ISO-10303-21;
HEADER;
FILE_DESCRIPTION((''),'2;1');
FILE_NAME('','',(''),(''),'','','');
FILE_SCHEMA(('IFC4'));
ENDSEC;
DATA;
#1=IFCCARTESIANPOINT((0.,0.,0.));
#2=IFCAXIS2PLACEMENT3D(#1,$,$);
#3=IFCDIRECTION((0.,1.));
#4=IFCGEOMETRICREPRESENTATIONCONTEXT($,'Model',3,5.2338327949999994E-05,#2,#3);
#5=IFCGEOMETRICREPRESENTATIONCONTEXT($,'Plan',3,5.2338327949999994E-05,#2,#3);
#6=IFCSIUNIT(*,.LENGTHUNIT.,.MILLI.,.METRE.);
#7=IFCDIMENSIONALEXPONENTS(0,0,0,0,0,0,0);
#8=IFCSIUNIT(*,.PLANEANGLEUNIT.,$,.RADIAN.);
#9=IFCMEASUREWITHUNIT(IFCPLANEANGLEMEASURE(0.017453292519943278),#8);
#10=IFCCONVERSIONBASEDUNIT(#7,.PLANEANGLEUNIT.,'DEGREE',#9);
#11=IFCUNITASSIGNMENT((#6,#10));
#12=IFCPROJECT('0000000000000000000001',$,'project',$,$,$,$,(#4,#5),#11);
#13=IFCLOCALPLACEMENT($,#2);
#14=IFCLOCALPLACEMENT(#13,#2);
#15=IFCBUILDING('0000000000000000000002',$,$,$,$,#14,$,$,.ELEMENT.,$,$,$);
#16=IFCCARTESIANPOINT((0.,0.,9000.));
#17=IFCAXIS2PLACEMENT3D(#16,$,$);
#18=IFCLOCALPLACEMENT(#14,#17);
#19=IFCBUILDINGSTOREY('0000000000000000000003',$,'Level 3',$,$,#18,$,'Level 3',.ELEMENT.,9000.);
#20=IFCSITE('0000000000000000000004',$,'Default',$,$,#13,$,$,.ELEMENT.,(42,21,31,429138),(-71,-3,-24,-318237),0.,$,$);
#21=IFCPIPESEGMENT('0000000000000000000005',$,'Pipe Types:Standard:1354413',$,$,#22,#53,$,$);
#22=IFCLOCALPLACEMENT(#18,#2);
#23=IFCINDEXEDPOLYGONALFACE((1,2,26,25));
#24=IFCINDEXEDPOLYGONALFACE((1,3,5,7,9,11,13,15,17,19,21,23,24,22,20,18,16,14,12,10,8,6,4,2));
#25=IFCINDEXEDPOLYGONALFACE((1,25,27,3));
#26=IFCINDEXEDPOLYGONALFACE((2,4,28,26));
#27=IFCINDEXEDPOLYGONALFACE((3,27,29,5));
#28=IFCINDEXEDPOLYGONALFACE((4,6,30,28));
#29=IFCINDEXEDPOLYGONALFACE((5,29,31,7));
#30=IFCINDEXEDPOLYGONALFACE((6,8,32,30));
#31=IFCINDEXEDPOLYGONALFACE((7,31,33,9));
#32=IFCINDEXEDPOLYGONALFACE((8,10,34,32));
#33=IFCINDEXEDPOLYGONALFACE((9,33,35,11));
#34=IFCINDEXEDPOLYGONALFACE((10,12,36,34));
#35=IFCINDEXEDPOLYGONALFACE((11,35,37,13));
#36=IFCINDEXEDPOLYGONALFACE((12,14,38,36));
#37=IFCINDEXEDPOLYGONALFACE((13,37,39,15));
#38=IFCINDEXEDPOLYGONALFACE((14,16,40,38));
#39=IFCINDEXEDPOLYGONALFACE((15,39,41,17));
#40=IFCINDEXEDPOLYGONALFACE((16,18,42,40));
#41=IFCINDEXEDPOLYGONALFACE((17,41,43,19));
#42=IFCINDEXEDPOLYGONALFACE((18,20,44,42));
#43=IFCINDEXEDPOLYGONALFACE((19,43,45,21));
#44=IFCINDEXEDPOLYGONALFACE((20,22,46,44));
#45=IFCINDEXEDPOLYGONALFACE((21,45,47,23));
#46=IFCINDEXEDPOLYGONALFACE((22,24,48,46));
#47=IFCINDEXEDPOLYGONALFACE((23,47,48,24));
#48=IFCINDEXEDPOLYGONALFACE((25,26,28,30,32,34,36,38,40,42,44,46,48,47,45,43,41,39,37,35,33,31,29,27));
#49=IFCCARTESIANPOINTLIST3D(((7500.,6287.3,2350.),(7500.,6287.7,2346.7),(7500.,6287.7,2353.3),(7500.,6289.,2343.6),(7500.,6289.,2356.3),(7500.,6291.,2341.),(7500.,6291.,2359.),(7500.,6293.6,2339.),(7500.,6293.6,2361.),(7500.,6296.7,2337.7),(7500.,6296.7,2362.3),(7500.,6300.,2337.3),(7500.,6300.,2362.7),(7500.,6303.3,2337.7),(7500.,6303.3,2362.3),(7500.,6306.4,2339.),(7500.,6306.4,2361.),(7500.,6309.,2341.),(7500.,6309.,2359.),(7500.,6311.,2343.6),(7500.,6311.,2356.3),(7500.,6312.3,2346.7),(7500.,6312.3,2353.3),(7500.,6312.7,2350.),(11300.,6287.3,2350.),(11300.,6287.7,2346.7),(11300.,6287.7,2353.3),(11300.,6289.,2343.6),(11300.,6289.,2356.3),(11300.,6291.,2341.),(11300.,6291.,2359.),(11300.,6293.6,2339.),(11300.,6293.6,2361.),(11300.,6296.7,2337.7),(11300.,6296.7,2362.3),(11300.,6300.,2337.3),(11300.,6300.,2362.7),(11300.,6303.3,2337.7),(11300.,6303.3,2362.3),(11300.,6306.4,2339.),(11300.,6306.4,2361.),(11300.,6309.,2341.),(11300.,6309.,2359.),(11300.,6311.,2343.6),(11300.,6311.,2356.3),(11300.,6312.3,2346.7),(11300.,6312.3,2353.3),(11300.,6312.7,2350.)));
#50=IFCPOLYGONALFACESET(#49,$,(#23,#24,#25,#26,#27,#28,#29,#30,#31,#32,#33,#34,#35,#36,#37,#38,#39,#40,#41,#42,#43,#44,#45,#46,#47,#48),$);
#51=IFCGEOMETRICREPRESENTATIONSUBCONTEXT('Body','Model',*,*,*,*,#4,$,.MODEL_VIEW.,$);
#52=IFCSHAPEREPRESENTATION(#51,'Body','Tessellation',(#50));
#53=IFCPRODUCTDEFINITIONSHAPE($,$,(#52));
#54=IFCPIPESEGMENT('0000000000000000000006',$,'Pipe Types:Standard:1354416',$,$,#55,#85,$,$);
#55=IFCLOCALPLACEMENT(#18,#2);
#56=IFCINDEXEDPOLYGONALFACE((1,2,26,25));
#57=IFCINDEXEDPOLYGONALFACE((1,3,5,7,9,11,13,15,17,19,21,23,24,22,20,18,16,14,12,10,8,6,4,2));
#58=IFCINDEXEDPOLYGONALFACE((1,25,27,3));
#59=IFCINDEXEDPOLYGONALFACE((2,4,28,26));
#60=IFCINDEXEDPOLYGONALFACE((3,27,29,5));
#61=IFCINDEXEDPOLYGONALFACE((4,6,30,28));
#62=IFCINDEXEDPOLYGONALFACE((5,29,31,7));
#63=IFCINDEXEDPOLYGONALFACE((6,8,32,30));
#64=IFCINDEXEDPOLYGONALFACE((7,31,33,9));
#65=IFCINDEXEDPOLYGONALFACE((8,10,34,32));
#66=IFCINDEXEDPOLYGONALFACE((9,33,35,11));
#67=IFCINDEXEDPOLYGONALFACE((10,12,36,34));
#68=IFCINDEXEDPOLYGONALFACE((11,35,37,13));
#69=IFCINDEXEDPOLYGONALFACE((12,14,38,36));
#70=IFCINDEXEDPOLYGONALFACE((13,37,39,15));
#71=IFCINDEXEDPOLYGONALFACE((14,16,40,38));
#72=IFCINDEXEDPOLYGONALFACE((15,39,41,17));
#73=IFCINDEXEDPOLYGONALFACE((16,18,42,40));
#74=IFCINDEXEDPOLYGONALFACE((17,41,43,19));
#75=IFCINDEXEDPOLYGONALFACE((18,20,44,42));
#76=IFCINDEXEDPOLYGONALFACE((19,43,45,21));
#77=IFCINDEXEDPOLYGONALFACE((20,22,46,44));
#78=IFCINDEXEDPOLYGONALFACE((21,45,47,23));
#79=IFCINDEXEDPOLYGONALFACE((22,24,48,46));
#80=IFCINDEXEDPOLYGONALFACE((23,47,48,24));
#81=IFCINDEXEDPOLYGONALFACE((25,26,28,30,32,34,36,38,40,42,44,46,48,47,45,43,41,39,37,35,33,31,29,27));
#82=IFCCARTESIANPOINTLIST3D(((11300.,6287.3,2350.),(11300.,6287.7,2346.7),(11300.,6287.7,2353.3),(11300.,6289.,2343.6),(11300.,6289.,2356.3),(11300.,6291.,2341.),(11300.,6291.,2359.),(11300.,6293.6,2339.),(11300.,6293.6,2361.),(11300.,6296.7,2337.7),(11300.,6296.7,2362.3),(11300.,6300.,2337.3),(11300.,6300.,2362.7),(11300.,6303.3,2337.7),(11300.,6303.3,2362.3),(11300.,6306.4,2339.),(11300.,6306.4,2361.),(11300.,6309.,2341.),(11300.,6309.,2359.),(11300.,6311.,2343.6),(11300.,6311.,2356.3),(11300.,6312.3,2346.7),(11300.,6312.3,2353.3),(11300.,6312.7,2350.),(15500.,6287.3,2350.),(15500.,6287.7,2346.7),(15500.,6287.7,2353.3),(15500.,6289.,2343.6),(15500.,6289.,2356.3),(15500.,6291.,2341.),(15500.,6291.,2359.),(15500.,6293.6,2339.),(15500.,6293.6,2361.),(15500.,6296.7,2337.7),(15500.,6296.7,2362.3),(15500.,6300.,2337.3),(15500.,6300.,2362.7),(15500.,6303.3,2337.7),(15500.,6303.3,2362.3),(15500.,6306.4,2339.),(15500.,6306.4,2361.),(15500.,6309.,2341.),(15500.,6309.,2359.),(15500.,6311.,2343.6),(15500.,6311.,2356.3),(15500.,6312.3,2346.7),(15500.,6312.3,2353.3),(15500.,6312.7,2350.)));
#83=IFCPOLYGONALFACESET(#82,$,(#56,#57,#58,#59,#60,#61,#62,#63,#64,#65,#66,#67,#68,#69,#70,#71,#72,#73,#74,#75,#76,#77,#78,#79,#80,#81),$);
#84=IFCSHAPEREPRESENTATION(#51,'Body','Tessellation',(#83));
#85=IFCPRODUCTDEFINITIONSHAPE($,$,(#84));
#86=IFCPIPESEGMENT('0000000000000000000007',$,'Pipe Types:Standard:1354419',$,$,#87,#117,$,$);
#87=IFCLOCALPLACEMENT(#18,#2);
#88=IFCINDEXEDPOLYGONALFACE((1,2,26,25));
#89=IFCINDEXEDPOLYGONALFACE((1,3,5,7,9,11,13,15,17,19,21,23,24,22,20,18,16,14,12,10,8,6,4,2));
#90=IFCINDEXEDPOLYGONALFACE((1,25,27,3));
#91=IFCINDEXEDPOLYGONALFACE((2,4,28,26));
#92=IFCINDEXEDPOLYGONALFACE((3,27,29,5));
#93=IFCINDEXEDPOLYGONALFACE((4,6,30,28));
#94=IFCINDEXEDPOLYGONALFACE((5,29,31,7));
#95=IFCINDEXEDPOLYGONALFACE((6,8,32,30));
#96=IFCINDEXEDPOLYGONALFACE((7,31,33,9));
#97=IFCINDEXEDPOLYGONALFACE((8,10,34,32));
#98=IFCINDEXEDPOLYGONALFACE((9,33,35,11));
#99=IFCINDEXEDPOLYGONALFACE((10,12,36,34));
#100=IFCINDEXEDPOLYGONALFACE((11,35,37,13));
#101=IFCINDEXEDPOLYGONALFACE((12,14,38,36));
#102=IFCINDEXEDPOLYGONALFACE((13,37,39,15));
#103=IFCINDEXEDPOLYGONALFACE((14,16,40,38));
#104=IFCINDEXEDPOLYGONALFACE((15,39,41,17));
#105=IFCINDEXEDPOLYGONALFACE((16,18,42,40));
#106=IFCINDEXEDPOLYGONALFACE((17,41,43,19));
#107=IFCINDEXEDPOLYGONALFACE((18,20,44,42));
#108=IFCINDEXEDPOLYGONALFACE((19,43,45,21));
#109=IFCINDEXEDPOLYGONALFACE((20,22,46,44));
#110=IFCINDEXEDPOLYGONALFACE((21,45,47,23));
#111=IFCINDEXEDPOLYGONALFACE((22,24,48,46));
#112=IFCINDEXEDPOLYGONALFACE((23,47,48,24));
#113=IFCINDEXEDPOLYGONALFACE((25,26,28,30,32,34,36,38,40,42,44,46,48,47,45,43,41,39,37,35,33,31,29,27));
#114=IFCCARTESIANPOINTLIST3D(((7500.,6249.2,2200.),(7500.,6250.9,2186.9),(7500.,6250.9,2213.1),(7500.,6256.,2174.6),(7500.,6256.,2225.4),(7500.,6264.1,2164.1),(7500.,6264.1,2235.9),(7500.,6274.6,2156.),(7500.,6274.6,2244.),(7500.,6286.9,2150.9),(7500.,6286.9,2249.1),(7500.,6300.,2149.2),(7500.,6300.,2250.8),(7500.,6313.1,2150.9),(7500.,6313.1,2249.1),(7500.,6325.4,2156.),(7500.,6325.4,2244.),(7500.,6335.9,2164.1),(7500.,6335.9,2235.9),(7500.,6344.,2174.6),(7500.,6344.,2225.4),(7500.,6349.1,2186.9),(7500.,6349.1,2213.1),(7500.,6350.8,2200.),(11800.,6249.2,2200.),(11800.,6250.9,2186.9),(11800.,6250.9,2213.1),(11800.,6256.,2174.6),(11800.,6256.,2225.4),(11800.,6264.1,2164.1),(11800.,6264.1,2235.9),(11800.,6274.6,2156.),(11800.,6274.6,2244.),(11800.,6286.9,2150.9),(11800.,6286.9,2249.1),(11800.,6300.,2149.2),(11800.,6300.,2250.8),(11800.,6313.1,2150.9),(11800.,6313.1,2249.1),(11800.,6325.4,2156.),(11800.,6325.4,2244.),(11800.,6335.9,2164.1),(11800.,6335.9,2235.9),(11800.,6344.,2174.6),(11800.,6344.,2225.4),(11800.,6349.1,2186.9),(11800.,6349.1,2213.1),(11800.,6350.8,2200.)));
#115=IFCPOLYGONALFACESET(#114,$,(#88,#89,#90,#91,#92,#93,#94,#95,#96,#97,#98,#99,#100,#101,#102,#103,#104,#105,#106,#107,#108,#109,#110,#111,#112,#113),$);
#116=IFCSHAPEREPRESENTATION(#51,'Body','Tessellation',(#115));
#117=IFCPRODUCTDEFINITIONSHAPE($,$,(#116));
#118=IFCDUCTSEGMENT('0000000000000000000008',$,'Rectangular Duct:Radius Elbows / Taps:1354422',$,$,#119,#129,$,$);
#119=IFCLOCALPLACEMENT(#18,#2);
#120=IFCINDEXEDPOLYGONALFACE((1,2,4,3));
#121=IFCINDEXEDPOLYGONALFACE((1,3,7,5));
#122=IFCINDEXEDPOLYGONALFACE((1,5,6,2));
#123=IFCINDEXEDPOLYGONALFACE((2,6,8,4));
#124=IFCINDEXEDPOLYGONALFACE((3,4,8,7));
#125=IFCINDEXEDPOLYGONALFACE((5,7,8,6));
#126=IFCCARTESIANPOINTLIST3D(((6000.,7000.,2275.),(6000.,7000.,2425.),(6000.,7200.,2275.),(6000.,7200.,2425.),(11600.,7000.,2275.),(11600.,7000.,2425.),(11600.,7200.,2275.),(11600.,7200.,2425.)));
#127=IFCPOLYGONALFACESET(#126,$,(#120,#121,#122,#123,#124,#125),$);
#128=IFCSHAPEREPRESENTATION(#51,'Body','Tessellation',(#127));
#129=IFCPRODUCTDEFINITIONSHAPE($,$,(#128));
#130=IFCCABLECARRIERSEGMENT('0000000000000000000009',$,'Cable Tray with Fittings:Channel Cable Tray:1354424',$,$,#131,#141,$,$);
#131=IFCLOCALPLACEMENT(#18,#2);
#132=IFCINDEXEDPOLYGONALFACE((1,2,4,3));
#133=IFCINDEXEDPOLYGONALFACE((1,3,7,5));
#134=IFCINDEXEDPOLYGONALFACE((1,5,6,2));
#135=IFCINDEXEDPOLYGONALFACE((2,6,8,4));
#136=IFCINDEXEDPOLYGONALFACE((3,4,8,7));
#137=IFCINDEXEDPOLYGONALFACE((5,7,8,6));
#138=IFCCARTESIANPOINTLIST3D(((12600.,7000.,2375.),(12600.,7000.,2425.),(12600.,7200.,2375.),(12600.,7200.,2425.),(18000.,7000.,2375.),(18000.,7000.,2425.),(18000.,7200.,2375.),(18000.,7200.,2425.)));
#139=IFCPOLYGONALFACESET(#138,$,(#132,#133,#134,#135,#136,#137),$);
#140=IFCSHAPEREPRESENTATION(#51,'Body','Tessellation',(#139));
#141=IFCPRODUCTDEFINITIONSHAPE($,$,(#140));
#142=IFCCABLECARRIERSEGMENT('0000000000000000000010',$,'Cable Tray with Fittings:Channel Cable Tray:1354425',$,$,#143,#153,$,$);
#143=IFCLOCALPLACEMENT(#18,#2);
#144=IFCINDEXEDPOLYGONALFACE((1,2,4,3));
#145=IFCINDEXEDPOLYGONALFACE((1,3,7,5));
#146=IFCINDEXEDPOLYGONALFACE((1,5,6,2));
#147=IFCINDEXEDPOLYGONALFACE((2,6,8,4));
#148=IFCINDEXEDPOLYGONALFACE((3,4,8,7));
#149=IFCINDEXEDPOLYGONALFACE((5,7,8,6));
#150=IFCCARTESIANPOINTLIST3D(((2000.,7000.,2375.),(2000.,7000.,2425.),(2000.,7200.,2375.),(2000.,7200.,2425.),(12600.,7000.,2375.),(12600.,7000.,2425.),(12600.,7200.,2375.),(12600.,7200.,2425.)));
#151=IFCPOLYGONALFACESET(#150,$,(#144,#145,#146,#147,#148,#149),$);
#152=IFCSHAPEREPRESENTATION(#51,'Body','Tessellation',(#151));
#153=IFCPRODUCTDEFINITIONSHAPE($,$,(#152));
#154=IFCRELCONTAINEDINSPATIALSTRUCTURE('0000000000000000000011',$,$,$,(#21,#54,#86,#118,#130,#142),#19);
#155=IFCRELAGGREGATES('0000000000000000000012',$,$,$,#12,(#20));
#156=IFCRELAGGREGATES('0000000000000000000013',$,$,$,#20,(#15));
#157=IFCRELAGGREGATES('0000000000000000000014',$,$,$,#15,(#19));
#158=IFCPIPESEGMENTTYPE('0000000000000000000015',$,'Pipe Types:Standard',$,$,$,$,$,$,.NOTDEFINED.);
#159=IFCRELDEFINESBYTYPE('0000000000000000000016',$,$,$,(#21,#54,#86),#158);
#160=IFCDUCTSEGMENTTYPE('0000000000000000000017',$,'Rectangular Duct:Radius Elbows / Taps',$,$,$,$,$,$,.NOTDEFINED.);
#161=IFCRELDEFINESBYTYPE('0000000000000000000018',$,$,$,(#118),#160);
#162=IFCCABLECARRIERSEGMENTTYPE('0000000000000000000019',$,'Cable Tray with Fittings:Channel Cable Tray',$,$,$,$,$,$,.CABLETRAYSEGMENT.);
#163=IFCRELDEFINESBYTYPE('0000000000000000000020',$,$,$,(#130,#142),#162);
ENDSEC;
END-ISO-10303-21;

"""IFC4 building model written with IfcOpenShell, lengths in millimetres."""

from ifc_helpers import new_model, entity, si_unit, converted_unit, direction, frame, origin, place, context, subcontext, project, spatial, arc, indexed_curve, outline, extrude, type_object, element, save


model = new_model("IFC4")

# Units and contexts
model_context = context("Model", 3, precision=5.2338327949999994e-05, world=origin(), true_north=direction((0.0, 1.0)))
plan_context = context("Plan", 3, precision=5.2338327949999994e-05, world=origin(), true_north=direction((0.0, 1.0)))
body_context = subcontext(model_context, "Body", "Model", "MODEL_VIEW")
ifc_project = project(units=[si_unit("LENGTHUNIT", "METRE", prefix="MILLI"), converted_unit("PLANEANGLEUNIT", "DEGREE", entity("IfcPlaneAngleMeasure", 0.017453292519943278), si_unit("PLANEANGLEUNIT", "RADIAN"), dimensions=[0, 0, 0, 0, 0, 0, 0])], contexts=[model_context, plan_context])

# Site, building, storey
site_placement = place(None, origin())
site = spatial("IfcSite", under=ifc_project, at=site_placement, Name="Default", CompositionType="ELEMENT", RefLatitude=(42, 21, 31, 429138), RefLongitude=(-71, -3, -24, -318237), RefElevation=0.0)
building_placement = place(site_placement, origin())
building = spatial("IfcBuilding", under=site, at=building_placement, CompositionType="ELEMENT")
storey_placement = place(building_placement, frame((0.0, 0.0, 9000.0)))
storey = spatial("IfcBuildingStorey", under=building, at=storey_placement, Name="Level 3", LongName="Level 3", CompositionType="ELEMENT", Elevation=9000.0)

# Pipe segments
pipe_segment_type = type_object("IfcPipeSegmentType", Name="Pipe Types:Standard", PredefinedType="NOTDEFINED")
pipe_segment_1_placement = place(storey_placement, origin())
element("IfcPipeSegment", 1, at=pipe_segment_1_placement, inside=storey, type_object=pipe_segment_type, Name="Pipe Types:Standard:1354413", context=body_context, shape_type="SweptSolid", body=[
    extrude(outline(indexed_curve([(12.7, 0.0), (9.0, 9.0), (0.0, 12.7), (-9.0, 9.0), (-12.7, 0.0), (-9.0, -9.0), (0.0, -12.7), (9.0, -9.0)], segments=[arc(1, 2, 3), arc(3, 4, 5), arc(5, 6, 7), arc(7, 8, 1)], self_intersect=False)), frame((7500.0, 6300.0, 2350.0), z_axis=(1.0, 0.0, 0.0), x_axis=(0.0, 1.0, 0.0)), (0.0, 0.0, 1.0), 3800.0),
])
pipe_segment_2_placement = place(storey_placement, origin())
element("IfcPipeSegment", 2, at=pipe_segment_2_placement, inside=storey, type_object=pipe_segment_type, Name="Pipe Types:Standard:1354416", context=body_context, shape_type="SweptSolid", body=[
    extrude(outline(indexed_curve([(12.7, 0.0), (9.0, 9.0), (0.0, 12.7), (-9.0, 9.0), (-12.7, 0.0), (-9.0, -9.0), (0.0, -12.7), (9.0, -9.0)], segments=[arc(1, 2, 3), arc(3, 4, 5), arc(5, 6, 7), arc(7, 8, 1)], self_intersect=False)), frame((11300.0, 6300.0, 2350.0), z_axis=(1.0, 0.0, 0.0), x_axis=(0.0, -1.0, 0.0)), (0.0, 0.0, 1.0), 4200.0),
])
pipe_segment_3_placement = place(storey_placement, origin())
element("IfcPipeSegment", 3, at=pipe_segment_3_placement, inside=storey, type_object=pipe_segment_type, Name="Pipe Types:Standard:1354419", context=body_context, shape_type="SweptSolid", body=[
    extrude(outline(indexed_curve([(50.8, 0.0), (35.9, 35.9), (0.0, 50.8), (-35.9, 35.9), (-50.8, 0.0), (-35.9, -35.9), (0.0, -50.8), (35.9, -35.9)], segments=[arc(1, 2, 3), arc(3, 4, 5), arc(5, 6, 7), arc(7, 8, 1)], self_intersect=False)), frame((7500.0, 6300.0, 2200.0), z_axis=(1.0, 0.0, 0.0), x_axis=(0.0, 1.0, 0.0)), (0.0, 0.0, 1.0), 4300.0),
])

# Duct segment
duct_segment_type = type_object("IfcDuctSegmentType", Name="Rectangular Duct:Radius Elbows / Taps", PredefinedType="NOTDEFINED")
duct_segment_placement = place(storey_placement, origin())
element("IfcDuctSegment", 4, at=duct_segment_placement, inside=storey, type_object=duct_segment_type, Name="Rectangular Duct:Radius Elbows / Taps:1354422", context=body_context, shape_type="SweptSolid", body=[
    extrude(outline(indexed_curve([(-2800.0, -100.0), (2800.0, -100.0), (2800.0, 100.0), (-2800.0, 100.0), (-2800.0, -100.0)], self_intersect=False)), frame((8800.0, 7100.0, 2275.0), z_axis=(0.0, 0.0, 1.0), x_axis=(-1.0, 0.0, 0.0)), (0.0, 0.0, 1.0), 150.0),
])

# Cable carrier segments
cable_carrier_segment_type = type_object("IfcCableCarrierSegmentType", Name="Cable Tray with Fittings:Channel Cable Tray", PredefinedType="CABLETRAYSEGMENT")
cable_carrier_segment_1_placement = place(storey_placement, origin())
element("IfcCableCarrierSegment", 5, at=cable_carrier_segment_1_placement, inside=storey, type_object=cable_carrier_segment_type, Name="Cable Tray with Fittings:Channel Cable Tray:1354424", context=body_context, shape_type="SweptSolid", body=[
    extrude(outline(indexed_curve([(-2700.0, -100.0), (2700.0, -100.0), (2700.0, 100.0), (-2700.0, 100.0), (-2700.0, -100.0)], self_intersect=False)), frame((15300.0, 7100.0, 2375.0)), (0.0, 0.0, 1.0), 50.0),
])
cable_carrier_segment_2_placement = place(storey_placement, origin())
element("IfcCableCarrierSegment", 6, at=cable_carrier_segment_2_placement, inside=storey, type_object=cable_carrier_segment_type, Name="Cable Tray with Fittings:Channel Cable Tray:1354425", context=body_context, shape_type="SweptSolid", body=[
    extrude(outline(indexed_curve([(-5300.0, -100.0), (5300.0, -100.0), (5300.0, 100.0), (-5300.0, 100.0), (-5300.0, -100.0)], self_intersect=False)), frame((7300.0, 7100.0, 2375.0), z_axis=(0.0, 0.0, 1.0), x_axis=(-1.0, 0.0, 0.0)), (0.0, 0.0, 1.0), 50.0),
])

save(model, "model.ifc")
